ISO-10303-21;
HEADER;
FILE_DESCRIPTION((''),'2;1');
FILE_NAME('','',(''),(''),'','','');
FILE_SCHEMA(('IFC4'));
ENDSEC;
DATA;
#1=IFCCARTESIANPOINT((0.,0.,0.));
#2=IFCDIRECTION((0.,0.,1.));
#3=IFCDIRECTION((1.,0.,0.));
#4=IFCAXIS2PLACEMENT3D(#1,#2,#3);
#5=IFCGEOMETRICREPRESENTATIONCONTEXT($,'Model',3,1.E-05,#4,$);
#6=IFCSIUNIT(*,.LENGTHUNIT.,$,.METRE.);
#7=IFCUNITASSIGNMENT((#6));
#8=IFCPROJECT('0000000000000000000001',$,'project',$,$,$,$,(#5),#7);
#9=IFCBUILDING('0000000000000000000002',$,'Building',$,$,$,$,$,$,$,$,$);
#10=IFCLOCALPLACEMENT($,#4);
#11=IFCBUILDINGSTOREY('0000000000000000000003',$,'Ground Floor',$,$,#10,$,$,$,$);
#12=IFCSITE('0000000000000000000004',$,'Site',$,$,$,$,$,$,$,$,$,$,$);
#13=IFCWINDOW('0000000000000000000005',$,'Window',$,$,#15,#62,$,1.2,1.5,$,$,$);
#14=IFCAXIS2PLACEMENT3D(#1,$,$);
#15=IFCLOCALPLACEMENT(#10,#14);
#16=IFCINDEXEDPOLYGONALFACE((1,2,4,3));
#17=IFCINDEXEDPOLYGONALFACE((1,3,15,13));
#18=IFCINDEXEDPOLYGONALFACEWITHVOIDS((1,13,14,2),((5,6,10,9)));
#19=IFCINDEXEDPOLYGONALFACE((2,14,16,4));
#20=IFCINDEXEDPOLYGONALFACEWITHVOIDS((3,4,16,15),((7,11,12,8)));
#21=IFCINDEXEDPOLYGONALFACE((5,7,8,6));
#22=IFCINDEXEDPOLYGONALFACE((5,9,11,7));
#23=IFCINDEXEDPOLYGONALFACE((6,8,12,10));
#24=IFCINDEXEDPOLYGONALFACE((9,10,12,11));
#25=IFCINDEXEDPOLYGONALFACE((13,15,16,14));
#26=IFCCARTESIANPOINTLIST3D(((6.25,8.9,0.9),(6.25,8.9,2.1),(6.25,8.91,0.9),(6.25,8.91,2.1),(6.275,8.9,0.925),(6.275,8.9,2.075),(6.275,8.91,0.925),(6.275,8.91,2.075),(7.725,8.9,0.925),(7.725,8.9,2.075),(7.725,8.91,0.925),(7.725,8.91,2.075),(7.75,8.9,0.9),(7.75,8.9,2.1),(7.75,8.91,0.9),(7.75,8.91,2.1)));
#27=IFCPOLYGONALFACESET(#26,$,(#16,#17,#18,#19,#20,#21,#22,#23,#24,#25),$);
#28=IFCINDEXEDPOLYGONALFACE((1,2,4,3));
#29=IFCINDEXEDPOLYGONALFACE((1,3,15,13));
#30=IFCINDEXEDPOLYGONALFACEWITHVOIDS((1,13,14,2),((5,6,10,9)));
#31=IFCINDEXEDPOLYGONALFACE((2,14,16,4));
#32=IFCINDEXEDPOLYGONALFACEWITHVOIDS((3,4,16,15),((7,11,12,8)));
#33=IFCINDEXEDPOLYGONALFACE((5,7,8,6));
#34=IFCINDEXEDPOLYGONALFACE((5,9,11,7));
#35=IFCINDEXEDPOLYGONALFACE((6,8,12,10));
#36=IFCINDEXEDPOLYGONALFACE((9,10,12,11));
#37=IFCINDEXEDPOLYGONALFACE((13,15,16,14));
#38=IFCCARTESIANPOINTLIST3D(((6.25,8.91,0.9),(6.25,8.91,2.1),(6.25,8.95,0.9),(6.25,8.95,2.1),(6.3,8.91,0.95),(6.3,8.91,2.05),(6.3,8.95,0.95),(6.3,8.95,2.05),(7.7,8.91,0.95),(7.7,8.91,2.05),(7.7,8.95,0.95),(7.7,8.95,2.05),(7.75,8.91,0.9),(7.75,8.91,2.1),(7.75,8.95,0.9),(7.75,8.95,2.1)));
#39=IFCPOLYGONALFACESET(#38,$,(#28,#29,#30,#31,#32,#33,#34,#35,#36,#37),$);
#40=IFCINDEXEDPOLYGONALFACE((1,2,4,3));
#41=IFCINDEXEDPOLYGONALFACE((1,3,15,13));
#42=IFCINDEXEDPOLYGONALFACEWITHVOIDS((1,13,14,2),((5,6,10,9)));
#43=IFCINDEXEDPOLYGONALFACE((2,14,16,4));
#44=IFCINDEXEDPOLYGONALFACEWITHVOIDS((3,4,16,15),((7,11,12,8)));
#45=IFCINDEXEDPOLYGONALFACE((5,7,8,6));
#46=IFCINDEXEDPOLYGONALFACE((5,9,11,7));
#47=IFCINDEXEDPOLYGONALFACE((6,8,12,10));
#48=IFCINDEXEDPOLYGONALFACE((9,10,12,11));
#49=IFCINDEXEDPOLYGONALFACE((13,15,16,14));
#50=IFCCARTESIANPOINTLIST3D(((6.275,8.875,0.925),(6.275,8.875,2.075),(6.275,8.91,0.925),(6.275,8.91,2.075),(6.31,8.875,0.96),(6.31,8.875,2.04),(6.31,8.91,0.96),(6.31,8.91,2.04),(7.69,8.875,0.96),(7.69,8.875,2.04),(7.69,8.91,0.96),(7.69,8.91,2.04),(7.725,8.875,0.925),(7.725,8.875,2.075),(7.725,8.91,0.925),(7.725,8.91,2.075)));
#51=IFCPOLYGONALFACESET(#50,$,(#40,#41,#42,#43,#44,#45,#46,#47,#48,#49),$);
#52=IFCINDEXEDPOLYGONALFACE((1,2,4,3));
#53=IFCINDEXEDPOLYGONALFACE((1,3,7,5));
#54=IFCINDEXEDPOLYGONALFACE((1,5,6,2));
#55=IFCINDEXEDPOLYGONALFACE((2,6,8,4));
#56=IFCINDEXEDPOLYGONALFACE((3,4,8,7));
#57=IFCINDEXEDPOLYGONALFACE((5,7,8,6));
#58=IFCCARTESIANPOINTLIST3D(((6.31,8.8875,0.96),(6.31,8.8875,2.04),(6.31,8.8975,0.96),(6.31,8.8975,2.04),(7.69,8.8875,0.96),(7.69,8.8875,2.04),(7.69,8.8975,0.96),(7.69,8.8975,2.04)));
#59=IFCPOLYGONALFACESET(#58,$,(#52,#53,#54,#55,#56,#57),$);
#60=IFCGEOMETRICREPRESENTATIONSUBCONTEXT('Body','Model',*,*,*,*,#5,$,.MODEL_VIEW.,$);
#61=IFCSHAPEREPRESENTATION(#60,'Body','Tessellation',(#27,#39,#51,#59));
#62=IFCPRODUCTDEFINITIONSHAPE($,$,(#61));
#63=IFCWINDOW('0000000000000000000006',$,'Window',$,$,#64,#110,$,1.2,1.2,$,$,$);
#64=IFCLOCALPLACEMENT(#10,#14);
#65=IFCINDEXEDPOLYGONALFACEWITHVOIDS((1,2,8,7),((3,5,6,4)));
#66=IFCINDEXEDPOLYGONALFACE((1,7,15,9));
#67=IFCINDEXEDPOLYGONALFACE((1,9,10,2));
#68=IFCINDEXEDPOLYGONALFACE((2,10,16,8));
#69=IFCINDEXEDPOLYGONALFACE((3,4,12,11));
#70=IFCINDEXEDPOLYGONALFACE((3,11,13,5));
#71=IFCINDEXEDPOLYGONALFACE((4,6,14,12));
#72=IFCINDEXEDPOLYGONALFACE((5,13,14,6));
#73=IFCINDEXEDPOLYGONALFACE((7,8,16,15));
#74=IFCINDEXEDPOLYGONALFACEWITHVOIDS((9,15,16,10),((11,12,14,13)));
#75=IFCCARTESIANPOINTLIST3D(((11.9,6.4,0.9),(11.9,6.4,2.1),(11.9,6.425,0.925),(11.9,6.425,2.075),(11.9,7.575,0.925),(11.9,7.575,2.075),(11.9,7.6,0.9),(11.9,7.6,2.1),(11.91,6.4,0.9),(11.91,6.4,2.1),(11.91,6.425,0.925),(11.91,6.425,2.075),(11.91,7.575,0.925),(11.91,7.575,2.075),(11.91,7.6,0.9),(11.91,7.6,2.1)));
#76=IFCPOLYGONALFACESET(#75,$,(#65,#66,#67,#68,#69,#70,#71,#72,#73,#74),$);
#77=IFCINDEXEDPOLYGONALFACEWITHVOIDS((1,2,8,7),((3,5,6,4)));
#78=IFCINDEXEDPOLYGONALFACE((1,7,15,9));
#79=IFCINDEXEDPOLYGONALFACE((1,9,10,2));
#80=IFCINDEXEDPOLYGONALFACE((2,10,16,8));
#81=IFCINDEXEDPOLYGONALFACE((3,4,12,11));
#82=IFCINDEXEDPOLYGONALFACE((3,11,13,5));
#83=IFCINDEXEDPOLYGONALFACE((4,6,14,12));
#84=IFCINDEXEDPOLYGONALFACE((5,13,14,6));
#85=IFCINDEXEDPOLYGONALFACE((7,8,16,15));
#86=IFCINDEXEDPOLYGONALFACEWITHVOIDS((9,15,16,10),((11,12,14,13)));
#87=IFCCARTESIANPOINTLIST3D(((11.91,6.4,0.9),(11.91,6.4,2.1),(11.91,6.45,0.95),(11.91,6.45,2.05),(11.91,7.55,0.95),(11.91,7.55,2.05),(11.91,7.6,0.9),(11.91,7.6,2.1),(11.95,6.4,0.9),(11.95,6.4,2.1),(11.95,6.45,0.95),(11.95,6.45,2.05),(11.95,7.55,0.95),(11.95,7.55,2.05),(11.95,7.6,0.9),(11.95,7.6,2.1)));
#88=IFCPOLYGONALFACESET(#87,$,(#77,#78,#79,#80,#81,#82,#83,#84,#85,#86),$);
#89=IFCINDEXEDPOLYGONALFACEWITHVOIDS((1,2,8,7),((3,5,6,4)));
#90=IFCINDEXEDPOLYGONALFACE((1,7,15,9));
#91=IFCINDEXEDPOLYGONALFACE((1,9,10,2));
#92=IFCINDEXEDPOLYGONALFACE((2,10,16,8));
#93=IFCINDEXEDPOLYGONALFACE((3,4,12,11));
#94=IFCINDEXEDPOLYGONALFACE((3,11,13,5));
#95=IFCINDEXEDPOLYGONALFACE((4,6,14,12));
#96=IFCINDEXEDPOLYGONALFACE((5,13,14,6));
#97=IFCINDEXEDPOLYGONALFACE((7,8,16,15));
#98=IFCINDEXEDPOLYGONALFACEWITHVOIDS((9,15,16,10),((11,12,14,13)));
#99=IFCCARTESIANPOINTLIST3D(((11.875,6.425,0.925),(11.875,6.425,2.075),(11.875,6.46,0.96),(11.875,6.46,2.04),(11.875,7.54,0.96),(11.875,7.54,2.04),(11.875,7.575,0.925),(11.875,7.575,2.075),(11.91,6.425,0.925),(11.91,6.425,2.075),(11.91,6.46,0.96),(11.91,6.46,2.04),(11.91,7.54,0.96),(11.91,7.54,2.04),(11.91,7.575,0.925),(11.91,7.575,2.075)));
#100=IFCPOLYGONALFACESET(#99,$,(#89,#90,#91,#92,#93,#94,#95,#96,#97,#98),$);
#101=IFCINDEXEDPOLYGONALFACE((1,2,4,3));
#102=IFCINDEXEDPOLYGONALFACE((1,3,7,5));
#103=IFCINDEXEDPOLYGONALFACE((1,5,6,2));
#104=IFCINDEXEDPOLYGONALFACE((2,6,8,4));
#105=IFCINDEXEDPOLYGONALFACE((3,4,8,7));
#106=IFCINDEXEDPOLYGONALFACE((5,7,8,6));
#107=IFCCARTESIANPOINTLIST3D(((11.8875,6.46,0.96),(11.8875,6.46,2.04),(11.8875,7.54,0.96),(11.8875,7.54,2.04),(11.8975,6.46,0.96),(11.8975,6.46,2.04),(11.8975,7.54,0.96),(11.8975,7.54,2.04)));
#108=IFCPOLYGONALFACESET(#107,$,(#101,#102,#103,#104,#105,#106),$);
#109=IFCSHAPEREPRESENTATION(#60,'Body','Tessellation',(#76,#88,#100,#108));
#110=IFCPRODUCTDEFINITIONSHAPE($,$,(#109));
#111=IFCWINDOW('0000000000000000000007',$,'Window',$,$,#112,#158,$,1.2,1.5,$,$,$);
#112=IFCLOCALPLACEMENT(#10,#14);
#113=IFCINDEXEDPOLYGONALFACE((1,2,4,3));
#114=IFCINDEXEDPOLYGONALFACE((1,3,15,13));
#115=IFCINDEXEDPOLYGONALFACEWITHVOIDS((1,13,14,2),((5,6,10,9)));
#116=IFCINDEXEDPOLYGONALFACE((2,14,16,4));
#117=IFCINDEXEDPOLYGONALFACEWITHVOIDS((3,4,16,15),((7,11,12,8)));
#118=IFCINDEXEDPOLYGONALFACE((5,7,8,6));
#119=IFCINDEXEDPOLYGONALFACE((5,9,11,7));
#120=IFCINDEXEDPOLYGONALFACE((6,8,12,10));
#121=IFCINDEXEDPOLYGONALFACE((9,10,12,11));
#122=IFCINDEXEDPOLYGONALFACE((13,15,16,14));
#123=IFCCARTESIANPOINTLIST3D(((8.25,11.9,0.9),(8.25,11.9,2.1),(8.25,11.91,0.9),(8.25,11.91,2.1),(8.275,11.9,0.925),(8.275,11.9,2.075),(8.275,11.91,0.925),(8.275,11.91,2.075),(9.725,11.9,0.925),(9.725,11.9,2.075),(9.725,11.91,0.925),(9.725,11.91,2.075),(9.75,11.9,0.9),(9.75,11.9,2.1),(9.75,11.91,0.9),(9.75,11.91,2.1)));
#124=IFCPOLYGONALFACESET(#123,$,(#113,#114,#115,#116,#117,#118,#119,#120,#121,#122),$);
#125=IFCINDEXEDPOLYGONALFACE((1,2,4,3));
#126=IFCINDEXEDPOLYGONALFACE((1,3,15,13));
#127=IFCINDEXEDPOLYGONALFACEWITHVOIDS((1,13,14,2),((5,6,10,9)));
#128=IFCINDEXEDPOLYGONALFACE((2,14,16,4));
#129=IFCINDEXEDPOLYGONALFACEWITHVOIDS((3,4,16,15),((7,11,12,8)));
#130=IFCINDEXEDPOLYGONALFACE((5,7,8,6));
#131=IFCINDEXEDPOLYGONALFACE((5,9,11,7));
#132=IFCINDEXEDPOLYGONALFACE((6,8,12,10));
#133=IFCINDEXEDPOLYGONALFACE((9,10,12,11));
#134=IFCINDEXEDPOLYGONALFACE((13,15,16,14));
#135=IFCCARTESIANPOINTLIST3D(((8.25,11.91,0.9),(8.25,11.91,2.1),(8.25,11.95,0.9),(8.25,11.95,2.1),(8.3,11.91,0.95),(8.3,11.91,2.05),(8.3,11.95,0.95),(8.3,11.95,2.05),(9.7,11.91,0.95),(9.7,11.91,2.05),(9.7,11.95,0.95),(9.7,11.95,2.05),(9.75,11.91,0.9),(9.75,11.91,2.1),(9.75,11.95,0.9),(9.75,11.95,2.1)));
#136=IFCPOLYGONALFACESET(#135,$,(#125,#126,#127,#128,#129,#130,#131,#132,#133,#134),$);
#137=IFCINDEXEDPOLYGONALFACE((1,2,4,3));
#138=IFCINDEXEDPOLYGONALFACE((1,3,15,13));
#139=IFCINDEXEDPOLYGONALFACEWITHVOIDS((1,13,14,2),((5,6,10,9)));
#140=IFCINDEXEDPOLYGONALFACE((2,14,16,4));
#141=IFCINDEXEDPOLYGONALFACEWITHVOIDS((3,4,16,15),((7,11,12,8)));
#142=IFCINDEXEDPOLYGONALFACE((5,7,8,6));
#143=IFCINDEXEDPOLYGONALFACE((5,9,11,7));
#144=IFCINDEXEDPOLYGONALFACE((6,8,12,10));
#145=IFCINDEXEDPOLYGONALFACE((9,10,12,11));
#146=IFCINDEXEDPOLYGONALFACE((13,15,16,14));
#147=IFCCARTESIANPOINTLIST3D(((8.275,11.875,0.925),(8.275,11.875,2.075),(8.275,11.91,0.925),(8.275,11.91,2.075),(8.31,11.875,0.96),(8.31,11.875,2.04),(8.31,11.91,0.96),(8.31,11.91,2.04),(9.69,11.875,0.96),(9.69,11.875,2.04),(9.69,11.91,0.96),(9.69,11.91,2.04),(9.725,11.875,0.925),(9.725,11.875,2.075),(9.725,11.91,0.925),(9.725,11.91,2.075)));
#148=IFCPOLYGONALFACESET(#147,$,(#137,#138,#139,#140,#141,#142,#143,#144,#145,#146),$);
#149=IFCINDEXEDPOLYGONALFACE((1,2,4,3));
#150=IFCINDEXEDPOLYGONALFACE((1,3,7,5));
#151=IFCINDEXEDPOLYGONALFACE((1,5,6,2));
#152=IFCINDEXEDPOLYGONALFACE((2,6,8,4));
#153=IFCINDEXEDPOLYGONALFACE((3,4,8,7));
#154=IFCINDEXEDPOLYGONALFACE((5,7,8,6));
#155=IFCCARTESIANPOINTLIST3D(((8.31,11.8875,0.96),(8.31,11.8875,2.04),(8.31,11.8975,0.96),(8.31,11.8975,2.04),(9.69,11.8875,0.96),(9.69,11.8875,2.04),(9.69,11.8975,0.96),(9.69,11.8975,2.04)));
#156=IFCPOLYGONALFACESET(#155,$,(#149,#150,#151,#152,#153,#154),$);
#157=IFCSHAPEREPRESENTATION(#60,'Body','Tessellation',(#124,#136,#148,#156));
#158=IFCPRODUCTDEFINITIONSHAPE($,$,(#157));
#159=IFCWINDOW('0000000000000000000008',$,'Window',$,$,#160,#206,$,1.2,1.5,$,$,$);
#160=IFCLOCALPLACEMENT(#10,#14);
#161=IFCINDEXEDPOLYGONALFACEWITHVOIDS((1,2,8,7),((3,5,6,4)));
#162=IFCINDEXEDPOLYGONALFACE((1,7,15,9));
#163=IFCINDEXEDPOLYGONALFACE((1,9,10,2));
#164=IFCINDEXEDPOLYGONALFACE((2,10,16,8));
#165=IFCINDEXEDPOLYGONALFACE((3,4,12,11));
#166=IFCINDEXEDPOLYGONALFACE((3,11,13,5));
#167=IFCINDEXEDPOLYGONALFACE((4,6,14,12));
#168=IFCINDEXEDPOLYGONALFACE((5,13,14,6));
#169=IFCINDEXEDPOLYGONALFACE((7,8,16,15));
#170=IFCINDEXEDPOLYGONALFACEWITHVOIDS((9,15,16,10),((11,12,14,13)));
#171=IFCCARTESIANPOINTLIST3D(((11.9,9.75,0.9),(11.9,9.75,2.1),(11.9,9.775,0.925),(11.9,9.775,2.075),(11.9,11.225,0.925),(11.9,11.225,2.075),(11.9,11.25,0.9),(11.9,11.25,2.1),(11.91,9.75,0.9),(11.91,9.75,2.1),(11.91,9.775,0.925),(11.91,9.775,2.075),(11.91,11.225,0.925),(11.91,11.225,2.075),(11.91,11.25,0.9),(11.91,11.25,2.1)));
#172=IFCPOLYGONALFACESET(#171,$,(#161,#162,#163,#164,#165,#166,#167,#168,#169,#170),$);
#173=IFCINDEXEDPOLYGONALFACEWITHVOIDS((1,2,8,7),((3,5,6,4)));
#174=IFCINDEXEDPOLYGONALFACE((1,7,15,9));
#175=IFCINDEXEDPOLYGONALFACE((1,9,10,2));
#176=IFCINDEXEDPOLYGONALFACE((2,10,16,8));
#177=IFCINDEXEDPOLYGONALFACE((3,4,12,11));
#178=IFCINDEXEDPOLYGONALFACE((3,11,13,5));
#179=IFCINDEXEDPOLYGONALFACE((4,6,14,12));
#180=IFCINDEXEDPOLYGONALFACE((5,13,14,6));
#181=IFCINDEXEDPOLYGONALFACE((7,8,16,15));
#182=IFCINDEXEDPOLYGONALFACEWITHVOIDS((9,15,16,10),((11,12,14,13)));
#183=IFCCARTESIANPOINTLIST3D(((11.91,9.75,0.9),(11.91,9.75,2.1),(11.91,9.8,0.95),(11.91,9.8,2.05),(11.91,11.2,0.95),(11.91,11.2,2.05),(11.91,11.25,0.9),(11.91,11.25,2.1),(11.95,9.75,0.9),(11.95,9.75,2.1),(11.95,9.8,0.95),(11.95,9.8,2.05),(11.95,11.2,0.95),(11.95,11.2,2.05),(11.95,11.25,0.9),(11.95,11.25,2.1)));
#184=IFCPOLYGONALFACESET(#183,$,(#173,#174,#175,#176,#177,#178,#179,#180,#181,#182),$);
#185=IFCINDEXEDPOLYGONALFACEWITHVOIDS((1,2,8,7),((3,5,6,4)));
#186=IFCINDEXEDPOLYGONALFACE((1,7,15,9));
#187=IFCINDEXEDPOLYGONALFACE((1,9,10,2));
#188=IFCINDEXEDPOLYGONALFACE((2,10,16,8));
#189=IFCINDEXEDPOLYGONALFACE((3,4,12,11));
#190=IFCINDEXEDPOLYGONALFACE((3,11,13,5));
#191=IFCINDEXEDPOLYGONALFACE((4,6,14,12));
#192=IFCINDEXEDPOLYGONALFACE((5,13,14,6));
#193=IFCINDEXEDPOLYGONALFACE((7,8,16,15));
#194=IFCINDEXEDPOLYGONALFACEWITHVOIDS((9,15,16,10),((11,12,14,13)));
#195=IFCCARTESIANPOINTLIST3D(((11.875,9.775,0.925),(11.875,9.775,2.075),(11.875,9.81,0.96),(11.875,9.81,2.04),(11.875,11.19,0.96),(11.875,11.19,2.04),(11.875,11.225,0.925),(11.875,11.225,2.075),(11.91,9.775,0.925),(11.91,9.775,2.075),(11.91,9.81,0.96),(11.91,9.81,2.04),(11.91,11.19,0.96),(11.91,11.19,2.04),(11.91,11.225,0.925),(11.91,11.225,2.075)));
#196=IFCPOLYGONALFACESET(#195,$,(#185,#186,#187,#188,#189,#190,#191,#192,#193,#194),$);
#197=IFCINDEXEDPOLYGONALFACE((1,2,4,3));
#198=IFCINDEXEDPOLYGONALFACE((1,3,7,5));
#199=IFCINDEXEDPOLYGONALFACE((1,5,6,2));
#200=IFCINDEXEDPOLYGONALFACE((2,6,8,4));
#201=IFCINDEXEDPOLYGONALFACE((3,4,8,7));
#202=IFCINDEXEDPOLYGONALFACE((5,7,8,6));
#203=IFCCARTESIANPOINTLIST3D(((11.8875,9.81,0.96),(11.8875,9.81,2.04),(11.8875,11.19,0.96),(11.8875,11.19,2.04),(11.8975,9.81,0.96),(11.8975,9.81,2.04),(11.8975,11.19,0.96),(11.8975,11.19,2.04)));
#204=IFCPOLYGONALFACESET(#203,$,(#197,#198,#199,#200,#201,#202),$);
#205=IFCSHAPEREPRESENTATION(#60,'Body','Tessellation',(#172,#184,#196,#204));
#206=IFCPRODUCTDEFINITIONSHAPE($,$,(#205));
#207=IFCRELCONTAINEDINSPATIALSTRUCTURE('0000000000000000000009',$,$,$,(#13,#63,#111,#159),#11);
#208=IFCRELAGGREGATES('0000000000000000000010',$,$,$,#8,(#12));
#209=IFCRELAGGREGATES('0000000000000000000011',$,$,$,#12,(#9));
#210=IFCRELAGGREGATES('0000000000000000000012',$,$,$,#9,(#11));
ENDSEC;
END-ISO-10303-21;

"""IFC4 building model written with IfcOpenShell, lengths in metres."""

from ifc_helpers import new_model, si_unit, frame, origin_with_axes, place, context, subcontext, project, spatial, line, indexed_curve, outline, extrude, element, save


model = new_model("IFC4")

# Units and contexts
model_context = context("Model", 3, precision=1e-05, world=origin_with_axes())
body_context = subcontext(model_context, "Body", "Model", "MODEL_VIEW")
ifc_project = project(units=[si_unit("LENGTHUNIT", "METRE")], contexts=[model_context])

# Site, building, storey
site = spatial("IfcSite", under=ifc_project, Name="Site")
building = spatial("IfcBuilding", under=site, Name="Building")
storey_placement = place(None, origin_with_axes())
storey = spatial("IfcBuildingStorey", under=building, at=storey_placement, Name="Ground Floor")

# Windows
window_1_placement = place(storey_placement, frame((7.75, 9.0, 0.9), z_axis=(0.0, 0.0, 1.0), x_axis=(-1.0, 0.0, 0.0)))
element("IfcWindow", 1, at=window_1_placement, inside=storey, Name="Window", OverallHeight=1.2, OverallWidth=1.5, context=body_context, shape_type="SweptSolid", body=[
    extrude(outline(indexed_curve([(0.0, 0.0), (1.5, 0.0), (1.5, 1.2), (0.0, 1.2)], segments=[line(1, 2, 3, 4, 1)]), holes=[indexed_curve([(0.025, 0.025), (1.475, 0.025), (1.475, 1.175), (0.025, 1.175)], segments=[line(1, 2, 3, 4, 1)])]), frame((0.0, 0.09, 0.0), z_axis=(0.0, -1.0, 0.0), x_axis=(1.0, 0.0, 0.0)), (0.0, 0.0, -1.0), 0.01),
    extrude(outline(indexed_curve([(0.0, 0.0), (1.5, 0.0), (1.5, 1.2), (0.0, 1.2)], segments=[line(1, 2, 3, 4, 1)]), holes=[indexed_curve([(0.05, 0.05), (1.45, 0.05), (1.45, 1.15), (0.05, 1.15)], segments=[line(1, 2, 3, 4, 1)])]), frame((0.0, 0.05, 0.0), z_axis=(0.0, -1.0, 0.0), x_axis=(1.0, 0.0, 0.0)), (0.0, 0.0, -1.0), 0.04),
    extrude(outline(indexed_curve([(0.0, 0.0), (1.45, 0.0), (1.45, 1.15), (0.0, 1.15)], segments=[line(1, 2, 3, 4, 1)]), holes=[indexed_curve([(0.035, 0.035), (1.415, 0.035), (1.415, 1.115), (0.035, 1.115)], segments=[line(1, 2, 3, 4, 1)])]), frame((0.025, 0.09, 0.025), z_axis=(0.0, -1.0, 0.0), x_axis=(1.0, 0.0, 0.0)), (0.0, 0.0, -1.0), 0.035),
    extrude(outline(indexed_curve([(0.035, 0.035), (1.415, 0.035), (1.415, 1.115), (0.035, 1.115)], segments=[line(1, 2, 3, 4, 1)])), frame((0.025, 0.1025, 0.025), z_axis=(0.0, -1.0, 0.0), x_axis=(1.0, 0.0, 0.0)), (0.0, 0.0, -1.0), 0.01),
])
window_2_placement = place(storey_placement, frame((12.0, 6.4, 0.9), z_axis=(0.0, 0.0, 1.0), x_axis=(0.0, 1.0, 0.0)))
element("IfcWindow", 2, at=window_2_placement, inside=storey, Name="Window", OverallHeight=1.2, OverallWidth=1.2, context=body_context, shape_type="SweptSolid", body=[
    extrude(outline(indexed_curve([(0.0, 0.0), (1.2, 0.0), (1.2, 1.2), (0.0, 1.2)], segments=[line(1, 2, 3, 4, 1)]), holes=[indexed_curve([(0.025, 0.025), (1.175, 0.025), (1.175, 1.175), (0.025, 1.175)], segments=[line(1, 2, 3, 4, 1)])]), frame((0.0, 0.09, 0.0), z_axis=(0.0, -1.0, 0.0), x_axis=(1.0, 0.0, 0.0)), (0.0, 0.0, -1.0), 0.01),
    extrude(outline(indexed_curve([(0.0, 0.0), (1.2, 0.0), (1.2, 1.2), (0.0, 1.2)], segments=[line(1, 2, 3, 4, 1)]), holes=[indexed_curve([(0.05, 0.05), (1.15, 0.05), (1.15, 1.15), (0.05, 1.15)], segments=[line(1, 2, 3, 4, 1)])]), frame((0.0, 0.05, 0.0), z_axis=(0.0, -1.0, 0.0), x_axis=(1.0, 0.0, 0.0)), (0.0, 0.0, -1.0), 0.04),
    extrude(outline(indexed_curve([(0.0, 0.0), (1.15, 0.0), (1.15, 1.15), (0.0, 1.15)], segments=[line(1, 2, 3, 4, 1)]), holes=[indexed_curve([(0.035, 0.035), (1.115, 0.035), (1.115, 1.115), (0.035, 1.115)], segments=[line(1, 2, 3, 4, 1)])]), frame((0.025, 0.09, 0.025), z_axis=(0.0, -1.0, 0.0), x_axis=(1.0, 0.0, 0.0)), (0.0, 0.0, -1.0), 0.035),
    extrude(outline(indexed_curve([(0.035, 0.035), (1.115, 0.035), (1.115, 1.115), (0.035, 1.115)], segments=[line(1, 2, 3, 4, 1)])), frame((0.025, 0.1025, 0.025), z_axis=(0.0, -1.0, 0.0), x_axis=(1.0, 0.0, 0.0)), (0.0, 0.0, -1.0), 0.01),
])
for number, where, z_axis, x_axis, name in (
    (3, (9.75, 12.0, 0.9), (0.0, 0.0, 1.0), (-1.0, 0.0, 0.0), "Window"),
    (4, (12.0, 9.75, 0.9), (0.0, 0.0, 1.0), (0.0, 1.0, 0.0), "Window"),
):
    element("IfcWindow", number, at=place(storey_placement, frame(where, z_axis=z_axis, x_axis=x_axis)), inside=storey, Name=name, OverallHeight=1.2, OverallWidth=1.5, context=body_context, shape_type="SweptSolid", body=[
        extrude(outline(indexed_curve([(0.0, 0.0), (1.5, 0.0), (1.5, 1.2), (0.0, 1.2)], segments=[line(1, 2, 3, 4, 1)]), holes=[indexed_curve([(0.025, 0.025), (1.475, 0.025), (1.475, 1.175), (0.025, 1.175)], segments=[line(1, 2, 3, 4, 1)])]), frame((0.0, 0.09, 0.0), z_axis=(0.0, -1.0, 0.0), x_axis=(1.0, 0.0, 0.0)), (0.0, 0.0, -1.0), 0.01),
        extrude(outline(indexed_curve([(0.0, 0.0), (1.5, 0.0), (1.5, 1.2), (0.0, 1.2)], segments=[line(1, 2, 3, 4, 1)]), holes=[indexed_curve([(0.05, 0.05), (1.45, 0.05), (1.45, 1.15), (0.05, 1.15)], segments=[line(1, 2, 3, 4, 1)])]), frame((0.0, 0.05, 0.0), z_axis=(0.0, -1.0, 0.0), x_axis=(1.0, 0.0, 0.0)), (0.0, 0.0, -1.0), 0.04),
        extrude(outline(indexed_curve([(0.0, 0.0), (1.45, 0.0), (1.45, 1.15), (0.0, 1.15)], segments=[line(1, 2, 3, 4, 1)]), holes=[indexed_curve([(0.035, 0.035), (1.415, 0.035), (1.415, 1.115), (0.035, 1.115)], segments=[line(1, 2, 3, 4, 1)])]), frame((0.025, 0.09, 0.025), z_axis=(0.0, -1.0, 0.0), x_axis=(1.0, 0.0, 0.0)), (0.0, 0.0, -1.0), 0.035),
        extrude(outline(indexed_curve([(0.035, 0.035), (1.415, 0.035), (1.415, 1.115), (0.035, 1.115)], segments=[line(1, 2, 3, 4, 1)])), frame((0.025, 0.1025, 0.025), z_axis=(0.0, -1.0, 0.0), x_axis=(1.0, 0.0, 0.0)), (0.0, 0.0, -1.0), 0.01),
    ])

save(model, "model.ifc")
